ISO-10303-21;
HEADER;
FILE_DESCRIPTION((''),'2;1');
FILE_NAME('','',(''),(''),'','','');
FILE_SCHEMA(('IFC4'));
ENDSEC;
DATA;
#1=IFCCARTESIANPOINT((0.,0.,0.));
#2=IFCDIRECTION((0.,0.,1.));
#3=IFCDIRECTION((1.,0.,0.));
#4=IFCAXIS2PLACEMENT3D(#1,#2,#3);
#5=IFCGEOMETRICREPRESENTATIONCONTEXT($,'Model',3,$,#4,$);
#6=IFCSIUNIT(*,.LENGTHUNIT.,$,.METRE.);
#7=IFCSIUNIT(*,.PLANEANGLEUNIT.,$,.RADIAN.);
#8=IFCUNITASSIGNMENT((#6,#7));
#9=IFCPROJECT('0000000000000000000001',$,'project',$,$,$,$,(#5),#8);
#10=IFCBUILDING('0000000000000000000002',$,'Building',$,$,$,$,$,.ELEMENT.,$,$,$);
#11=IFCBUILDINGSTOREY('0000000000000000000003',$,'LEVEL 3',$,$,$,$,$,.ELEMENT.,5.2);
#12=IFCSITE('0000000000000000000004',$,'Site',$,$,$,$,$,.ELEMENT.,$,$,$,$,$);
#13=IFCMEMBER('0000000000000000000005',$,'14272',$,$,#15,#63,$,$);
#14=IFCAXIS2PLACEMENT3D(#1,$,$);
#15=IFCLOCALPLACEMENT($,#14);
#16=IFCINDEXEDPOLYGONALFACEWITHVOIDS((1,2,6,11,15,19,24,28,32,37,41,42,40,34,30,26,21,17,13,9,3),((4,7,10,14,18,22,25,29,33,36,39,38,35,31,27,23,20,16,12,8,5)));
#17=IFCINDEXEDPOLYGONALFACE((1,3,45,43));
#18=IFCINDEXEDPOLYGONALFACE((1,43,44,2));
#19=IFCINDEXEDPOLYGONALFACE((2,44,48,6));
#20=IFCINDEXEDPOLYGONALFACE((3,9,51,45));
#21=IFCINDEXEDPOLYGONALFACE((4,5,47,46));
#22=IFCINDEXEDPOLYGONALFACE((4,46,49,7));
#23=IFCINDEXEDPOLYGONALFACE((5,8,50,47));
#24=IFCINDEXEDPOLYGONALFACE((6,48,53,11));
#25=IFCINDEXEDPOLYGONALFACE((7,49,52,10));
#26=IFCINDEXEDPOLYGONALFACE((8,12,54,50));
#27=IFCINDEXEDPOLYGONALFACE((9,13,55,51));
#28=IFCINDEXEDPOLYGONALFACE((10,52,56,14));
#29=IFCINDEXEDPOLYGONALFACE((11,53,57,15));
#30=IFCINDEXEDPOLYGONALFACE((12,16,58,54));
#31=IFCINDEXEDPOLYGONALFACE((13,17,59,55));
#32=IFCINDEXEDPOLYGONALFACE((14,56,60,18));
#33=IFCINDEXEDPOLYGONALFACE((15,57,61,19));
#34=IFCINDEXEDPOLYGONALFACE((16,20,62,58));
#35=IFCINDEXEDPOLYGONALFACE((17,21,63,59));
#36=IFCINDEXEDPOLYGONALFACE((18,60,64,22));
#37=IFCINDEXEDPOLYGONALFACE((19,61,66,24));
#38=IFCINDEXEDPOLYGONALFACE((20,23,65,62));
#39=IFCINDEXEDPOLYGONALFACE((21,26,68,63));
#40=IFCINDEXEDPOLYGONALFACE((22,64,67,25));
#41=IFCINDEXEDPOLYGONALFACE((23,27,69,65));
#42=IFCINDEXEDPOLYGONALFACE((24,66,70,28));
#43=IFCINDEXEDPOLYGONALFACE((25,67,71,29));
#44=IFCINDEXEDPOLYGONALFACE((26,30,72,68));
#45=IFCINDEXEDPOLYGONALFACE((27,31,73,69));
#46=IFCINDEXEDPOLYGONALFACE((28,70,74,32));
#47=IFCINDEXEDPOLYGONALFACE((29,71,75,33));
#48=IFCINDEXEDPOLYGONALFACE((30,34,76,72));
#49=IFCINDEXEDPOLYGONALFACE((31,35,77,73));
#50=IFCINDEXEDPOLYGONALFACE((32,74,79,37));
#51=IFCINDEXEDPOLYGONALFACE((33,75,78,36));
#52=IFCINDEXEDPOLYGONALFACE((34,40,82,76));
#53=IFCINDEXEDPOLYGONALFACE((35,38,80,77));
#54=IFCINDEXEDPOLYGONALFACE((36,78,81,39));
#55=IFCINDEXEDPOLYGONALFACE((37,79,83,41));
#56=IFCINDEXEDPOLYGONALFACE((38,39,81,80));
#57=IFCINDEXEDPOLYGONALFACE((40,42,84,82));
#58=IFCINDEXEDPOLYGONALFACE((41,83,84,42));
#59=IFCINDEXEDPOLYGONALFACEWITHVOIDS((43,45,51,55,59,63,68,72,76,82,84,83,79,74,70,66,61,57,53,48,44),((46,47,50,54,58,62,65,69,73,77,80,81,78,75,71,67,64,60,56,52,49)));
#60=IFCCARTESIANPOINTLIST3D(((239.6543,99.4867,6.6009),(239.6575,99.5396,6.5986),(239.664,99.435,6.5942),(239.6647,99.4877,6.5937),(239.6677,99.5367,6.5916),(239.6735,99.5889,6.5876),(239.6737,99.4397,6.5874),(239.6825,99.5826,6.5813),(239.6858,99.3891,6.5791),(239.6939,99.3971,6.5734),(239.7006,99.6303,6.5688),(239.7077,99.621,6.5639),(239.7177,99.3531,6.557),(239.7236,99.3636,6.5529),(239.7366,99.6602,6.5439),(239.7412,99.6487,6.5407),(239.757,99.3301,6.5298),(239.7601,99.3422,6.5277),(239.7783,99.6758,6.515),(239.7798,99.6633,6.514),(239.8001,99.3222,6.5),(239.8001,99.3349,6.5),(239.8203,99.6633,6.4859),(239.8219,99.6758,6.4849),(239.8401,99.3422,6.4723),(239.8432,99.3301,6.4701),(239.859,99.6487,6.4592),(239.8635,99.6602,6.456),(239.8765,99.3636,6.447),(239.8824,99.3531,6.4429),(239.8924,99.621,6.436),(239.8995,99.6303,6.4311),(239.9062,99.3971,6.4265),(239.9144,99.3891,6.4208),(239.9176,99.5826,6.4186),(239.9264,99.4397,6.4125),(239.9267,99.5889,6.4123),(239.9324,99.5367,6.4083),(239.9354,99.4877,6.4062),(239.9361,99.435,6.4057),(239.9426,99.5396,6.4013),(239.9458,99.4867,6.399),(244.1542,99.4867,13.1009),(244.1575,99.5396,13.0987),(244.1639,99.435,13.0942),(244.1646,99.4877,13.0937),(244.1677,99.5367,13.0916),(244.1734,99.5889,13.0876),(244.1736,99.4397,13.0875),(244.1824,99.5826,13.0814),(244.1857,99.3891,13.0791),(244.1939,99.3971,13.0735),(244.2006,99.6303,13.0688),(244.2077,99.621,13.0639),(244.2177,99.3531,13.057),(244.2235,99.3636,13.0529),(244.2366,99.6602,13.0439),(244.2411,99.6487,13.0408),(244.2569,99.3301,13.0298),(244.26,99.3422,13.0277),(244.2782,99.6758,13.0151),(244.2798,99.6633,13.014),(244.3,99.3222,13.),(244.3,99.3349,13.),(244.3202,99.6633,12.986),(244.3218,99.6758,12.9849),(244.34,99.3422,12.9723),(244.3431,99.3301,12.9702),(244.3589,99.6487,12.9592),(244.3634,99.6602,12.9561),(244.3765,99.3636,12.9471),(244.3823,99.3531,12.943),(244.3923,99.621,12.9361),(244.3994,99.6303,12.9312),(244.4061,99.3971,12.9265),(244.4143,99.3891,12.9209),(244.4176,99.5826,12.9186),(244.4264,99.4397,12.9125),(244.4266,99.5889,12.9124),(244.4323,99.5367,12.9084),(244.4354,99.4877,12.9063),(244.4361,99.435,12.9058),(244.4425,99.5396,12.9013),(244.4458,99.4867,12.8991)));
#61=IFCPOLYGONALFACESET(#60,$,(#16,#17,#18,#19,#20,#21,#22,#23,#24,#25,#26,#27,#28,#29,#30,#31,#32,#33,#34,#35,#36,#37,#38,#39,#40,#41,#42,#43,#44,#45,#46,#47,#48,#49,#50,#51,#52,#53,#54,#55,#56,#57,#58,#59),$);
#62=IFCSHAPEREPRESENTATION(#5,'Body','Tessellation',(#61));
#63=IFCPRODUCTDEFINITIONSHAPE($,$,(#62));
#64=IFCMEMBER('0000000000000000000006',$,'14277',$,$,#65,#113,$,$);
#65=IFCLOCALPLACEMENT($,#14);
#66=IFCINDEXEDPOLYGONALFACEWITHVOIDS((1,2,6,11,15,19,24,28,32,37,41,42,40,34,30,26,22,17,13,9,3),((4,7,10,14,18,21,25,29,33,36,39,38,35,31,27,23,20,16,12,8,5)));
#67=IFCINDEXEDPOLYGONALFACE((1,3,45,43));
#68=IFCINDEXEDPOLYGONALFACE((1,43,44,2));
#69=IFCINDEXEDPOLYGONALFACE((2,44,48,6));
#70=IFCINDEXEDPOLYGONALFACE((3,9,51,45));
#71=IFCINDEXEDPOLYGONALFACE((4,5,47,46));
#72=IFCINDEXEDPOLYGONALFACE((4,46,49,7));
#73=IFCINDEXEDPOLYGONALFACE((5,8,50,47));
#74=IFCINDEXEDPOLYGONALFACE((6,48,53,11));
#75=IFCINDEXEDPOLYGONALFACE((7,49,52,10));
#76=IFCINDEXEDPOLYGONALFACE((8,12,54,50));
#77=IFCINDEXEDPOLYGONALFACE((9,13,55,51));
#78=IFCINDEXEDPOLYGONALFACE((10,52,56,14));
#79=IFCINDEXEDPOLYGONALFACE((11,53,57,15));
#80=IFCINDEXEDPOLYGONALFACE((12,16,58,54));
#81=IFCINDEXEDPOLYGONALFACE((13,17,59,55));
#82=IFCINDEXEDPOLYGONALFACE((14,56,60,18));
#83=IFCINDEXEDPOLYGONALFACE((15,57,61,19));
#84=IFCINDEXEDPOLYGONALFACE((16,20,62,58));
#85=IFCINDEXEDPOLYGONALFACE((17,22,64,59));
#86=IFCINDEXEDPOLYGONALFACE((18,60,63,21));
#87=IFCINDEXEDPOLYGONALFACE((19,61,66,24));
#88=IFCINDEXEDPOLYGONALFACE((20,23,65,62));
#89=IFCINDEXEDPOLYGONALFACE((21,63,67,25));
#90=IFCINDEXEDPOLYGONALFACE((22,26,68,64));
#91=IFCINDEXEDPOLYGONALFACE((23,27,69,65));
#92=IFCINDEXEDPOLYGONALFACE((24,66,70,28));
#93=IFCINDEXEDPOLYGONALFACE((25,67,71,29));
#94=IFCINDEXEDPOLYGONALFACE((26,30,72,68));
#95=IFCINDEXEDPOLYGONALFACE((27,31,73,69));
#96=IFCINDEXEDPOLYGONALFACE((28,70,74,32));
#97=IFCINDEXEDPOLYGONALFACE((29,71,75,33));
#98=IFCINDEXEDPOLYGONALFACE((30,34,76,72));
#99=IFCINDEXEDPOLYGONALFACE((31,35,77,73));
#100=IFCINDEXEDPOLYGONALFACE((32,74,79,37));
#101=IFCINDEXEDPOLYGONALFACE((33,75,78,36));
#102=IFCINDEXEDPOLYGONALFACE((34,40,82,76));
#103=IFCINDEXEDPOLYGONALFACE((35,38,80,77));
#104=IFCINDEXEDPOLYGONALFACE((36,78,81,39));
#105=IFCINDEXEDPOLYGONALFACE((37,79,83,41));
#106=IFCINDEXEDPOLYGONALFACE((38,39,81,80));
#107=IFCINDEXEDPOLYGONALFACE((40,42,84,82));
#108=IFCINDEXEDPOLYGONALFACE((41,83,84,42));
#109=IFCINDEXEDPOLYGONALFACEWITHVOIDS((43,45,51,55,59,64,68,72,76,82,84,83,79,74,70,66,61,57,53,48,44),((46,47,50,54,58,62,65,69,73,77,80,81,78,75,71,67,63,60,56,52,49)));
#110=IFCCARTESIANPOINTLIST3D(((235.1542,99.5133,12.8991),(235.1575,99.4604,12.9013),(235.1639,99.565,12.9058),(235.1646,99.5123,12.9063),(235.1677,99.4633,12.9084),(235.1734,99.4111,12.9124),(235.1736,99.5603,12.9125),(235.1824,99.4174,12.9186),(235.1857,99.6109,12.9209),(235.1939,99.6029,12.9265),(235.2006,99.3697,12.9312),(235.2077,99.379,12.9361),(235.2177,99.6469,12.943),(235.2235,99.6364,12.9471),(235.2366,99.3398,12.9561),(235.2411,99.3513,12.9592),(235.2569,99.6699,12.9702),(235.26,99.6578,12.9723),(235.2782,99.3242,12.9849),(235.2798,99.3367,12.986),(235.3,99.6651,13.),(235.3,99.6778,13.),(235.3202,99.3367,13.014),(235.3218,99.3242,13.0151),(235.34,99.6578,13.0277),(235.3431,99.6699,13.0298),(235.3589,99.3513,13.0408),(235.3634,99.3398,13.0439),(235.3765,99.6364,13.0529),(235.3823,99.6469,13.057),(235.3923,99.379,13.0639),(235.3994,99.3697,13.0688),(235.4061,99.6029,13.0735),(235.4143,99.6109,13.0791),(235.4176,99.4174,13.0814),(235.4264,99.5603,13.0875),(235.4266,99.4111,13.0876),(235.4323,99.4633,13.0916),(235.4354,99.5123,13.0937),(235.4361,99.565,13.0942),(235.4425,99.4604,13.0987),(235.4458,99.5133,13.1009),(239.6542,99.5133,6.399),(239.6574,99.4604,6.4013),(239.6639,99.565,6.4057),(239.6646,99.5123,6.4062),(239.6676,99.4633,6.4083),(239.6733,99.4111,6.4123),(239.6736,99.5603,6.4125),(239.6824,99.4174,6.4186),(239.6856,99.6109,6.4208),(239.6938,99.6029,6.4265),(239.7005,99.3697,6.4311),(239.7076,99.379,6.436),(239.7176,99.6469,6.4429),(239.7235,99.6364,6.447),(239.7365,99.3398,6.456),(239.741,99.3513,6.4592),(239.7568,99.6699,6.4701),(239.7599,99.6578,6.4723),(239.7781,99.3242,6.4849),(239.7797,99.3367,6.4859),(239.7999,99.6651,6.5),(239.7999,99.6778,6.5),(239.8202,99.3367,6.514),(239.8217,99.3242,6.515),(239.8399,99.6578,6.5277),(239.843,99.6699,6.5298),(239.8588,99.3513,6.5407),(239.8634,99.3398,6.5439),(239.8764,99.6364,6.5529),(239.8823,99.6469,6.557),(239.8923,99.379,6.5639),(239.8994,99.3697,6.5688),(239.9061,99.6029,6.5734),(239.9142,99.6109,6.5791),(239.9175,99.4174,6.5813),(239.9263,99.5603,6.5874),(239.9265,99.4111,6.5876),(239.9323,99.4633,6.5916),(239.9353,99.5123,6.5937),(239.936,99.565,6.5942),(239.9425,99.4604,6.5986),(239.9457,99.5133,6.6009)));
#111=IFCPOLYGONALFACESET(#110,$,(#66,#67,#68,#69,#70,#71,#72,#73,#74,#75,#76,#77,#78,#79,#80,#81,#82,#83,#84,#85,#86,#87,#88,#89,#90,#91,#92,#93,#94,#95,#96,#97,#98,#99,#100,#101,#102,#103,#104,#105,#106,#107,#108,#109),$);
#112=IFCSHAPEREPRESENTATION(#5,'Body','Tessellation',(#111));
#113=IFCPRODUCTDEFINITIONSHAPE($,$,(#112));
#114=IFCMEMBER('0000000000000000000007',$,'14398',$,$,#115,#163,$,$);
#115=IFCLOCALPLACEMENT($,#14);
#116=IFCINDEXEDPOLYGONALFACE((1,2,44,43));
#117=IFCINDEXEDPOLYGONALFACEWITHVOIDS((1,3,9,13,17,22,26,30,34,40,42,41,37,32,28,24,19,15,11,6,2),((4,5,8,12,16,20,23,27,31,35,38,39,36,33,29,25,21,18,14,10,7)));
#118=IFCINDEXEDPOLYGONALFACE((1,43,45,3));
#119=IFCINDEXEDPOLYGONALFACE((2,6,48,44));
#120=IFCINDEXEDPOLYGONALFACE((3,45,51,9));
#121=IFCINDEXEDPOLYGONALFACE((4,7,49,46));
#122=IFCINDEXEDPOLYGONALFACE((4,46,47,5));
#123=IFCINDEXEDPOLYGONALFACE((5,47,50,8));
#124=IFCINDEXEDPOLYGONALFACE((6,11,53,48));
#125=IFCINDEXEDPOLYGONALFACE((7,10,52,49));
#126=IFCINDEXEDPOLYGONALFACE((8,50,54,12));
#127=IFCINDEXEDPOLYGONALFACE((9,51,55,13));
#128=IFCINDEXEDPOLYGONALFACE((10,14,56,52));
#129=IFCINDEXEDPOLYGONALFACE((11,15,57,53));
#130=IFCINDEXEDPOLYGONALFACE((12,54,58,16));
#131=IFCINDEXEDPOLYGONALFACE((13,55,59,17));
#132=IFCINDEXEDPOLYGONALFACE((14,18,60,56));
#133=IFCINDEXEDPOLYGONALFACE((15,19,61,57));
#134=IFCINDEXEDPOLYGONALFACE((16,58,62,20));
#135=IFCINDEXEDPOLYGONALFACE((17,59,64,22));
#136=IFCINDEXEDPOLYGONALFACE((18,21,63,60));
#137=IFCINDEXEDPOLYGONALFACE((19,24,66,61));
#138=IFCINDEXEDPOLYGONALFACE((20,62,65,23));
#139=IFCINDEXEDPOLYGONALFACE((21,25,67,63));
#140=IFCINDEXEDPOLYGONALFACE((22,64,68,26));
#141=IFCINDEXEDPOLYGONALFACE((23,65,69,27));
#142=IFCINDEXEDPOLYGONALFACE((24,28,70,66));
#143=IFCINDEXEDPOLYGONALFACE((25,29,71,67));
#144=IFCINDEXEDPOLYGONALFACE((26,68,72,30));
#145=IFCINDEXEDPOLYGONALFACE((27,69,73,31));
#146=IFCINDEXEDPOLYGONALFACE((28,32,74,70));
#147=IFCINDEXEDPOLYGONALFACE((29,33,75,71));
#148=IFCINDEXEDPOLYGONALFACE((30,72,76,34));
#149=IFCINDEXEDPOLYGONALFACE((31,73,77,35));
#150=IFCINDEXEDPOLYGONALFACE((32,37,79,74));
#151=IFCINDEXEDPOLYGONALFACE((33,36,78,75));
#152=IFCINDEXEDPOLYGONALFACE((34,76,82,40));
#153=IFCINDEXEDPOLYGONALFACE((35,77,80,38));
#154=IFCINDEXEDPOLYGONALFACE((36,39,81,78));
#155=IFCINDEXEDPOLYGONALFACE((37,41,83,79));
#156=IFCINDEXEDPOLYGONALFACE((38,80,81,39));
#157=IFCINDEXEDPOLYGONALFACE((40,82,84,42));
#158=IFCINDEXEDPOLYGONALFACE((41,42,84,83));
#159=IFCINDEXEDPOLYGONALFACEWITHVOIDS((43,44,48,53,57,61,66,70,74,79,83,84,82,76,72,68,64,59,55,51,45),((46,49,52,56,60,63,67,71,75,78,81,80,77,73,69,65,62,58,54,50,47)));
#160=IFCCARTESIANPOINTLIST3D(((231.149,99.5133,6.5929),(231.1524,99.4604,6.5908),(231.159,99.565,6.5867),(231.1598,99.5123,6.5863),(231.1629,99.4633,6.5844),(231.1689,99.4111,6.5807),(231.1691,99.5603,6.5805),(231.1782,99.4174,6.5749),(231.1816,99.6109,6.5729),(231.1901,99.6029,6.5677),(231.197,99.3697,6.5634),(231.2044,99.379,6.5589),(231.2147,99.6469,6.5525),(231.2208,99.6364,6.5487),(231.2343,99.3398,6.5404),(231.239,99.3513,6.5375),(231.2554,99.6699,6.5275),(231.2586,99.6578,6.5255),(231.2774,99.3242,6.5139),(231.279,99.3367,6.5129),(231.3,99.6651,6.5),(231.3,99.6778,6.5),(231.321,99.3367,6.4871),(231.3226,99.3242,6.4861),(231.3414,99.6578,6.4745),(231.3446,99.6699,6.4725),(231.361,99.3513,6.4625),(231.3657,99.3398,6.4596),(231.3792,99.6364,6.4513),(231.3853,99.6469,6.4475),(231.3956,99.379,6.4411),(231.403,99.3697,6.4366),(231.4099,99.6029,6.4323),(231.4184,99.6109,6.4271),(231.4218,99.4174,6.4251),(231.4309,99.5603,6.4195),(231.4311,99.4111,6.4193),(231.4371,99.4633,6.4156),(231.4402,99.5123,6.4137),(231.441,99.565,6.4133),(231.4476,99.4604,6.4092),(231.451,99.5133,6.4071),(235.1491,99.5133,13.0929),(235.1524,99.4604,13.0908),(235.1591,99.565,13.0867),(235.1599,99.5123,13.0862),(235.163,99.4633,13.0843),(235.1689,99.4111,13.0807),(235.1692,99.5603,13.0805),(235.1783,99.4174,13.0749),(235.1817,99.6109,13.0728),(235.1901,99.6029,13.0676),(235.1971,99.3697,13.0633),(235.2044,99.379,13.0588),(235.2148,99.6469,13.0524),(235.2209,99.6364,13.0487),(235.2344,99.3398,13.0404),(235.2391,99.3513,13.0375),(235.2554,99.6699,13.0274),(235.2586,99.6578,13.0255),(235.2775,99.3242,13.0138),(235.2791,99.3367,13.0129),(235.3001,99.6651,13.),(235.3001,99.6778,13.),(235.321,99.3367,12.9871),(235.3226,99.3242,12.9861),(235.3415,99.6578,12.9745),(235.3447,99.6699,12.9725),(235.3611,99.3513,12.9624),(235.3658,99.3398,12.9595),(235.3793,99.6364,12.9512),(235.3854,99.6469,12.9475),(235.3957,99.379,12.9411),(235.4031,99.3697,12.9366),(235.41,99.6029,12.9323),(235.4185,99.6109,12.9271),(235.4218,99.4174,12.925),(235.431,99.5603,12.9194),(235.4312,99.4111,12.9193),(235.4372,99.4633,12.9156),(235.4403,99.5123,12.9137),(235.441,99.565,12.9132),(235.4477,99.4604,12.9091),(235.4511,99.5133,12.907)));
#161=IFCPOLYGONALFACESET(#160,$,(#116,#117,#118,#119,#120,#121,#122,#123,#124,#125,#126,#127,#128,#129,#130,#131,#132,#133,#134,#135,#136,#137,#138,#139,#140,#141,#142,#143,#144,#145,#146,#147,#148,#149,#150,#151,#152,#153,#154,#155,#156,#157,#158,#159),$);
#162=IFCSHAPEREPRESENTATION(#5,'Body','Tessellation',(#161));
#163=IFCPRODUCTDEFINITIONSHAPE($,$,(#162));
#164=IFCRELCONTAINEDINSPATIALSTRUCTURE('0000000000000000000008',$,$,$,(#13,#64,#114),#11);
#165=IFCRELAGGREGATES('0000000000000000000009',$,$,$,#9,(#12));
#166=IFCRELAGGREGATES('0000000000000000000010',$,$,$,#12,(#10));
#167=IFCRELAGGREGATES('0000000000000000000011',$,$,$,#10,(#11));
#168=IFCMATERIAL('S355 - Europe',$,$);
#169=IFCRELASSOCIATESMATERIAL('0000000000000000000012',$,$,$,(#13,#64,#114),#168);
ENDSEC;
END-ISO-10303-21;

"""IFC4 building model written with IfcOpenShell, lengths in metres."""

from ifc_helpers import new_model, si_unit, frame, origin_with_axes, origin_2d_with_axis, place, context, project, spatial, hollow_circle, extrude, material, material_profile, profile_set, profile_usage, element, save


model = new_model("IFC4")

# Units and contexts
model_context = context("Model", 3, world=origin_with_axes())
ifc_project = project(units=[si_unit("LENGTHUNIT", "METRE"), si_unit("PLANEANGLEUNIT", "RADIAN")], contexts=[model_context])

# Site, building, storey
site = spatial("IfcSite", under=ifc_project, Name="Site", CompositionType="ELEMENT")
building = spatial("IfcBuilding", under=site, Name="Building", CompositionType="ELEMENT")
storey = spatial("IfcBuildingStorey", under=building, Name="LEVEL 3", CompositionType="ELEMENT", Elevation=5.2)

# Shared definitions
ifc_material = material(Name="S355 - Europe")

# Members
ifc_material_profile_1 = material_profile(ifc_material, hollow_circle(Radius=0.1778, WallThickness=0.0127, at=origin_2d_with_axis()))
ifc_profile_set_1 = profile_set([ifc_material_profile_1])
ifc_profile_usage_1 = profile_usage(ifc_profile_set_1, cardinal=10)
member_1_placement = place(None, frame((244.3, 99.5, 13.0), z_axis=(-0.569201, 0.0, -0.822198), x_axis=(0.0, -1.0, 0.0)))
element("IfcMember", 1, at=member_1_placement, inside=storey, material=ifc_profile_usage_1, Name="14272", context=model_context, shape_type="SweptSolid", body=[
    extrude(hollow_circle(Radius=0.1778, WallThickness=0.0127, at=origin_2d_with_axis()), origin_with_axes(), (0.0, 0.0, 1.0), 7.9057),
])
ifc_material_profile_2 = material_profile(ifc_material, hollow_circle(Radius=0.1778, WallThickness=0.0127, at=origin_2d_with_axis()))
ifc_profile_set_2 = profile_set([ifc_material_profile_2])
ifc_profile_usage_2 = profile_usage(ifc_profile_set_2, cardinal=10)
member_2_placement = place(None, frame((235.3, 99.5, 13.0), z_axis=(0.569201, 0.0, -0.822198), x_axis=(0.0, 1.0, 0.0)))
element("IfcMember", 2, at=member_2_placement, inside=storey, material=ifc_profile_usage_2, Name="14277", context=model_context, shape_type="SweptSolid", body=[
    extrude(hollow_circle(Radius=0.1778, WallThickness=0.0127, at=origin_2d_with_axis()), origin_with_axes(), (0.0, 0.0, 1.0), 7.9057),
])
ifc_material_profile_3 = material_profile(ifc_material, hollow_circle(Radius=0.1778, WallThickness=0.0127, at=origin_2d_with_axis()))
ifc_profile_set_3 = profile_set([ifc_material_profile_3])
ifc_profile_usage_3 = profile_usage(ifc_profile_set_3, cardinal=10)
member_3_placement = place(None, frame((231.3, 99.5, 6.5), z_axis=(0.524107, 0.0, 0.851652), x_axis=(0.0, 1.0, 0.0)))
element("IfcMember", 3, at=member_3_placement, inside=storey, material=ifc_profile_usage_3, Name="14398", context=model_context, shape_type="SweptSolid", body=[
    extrude(hollow_circle(Radius=0.1778, WallThickness=0.0127, at=origin_2d_with_axis()), origin_with_axes(), (0.0, 0.0, 1.0), 7.6322),
])

save(model, "model.ifc")
